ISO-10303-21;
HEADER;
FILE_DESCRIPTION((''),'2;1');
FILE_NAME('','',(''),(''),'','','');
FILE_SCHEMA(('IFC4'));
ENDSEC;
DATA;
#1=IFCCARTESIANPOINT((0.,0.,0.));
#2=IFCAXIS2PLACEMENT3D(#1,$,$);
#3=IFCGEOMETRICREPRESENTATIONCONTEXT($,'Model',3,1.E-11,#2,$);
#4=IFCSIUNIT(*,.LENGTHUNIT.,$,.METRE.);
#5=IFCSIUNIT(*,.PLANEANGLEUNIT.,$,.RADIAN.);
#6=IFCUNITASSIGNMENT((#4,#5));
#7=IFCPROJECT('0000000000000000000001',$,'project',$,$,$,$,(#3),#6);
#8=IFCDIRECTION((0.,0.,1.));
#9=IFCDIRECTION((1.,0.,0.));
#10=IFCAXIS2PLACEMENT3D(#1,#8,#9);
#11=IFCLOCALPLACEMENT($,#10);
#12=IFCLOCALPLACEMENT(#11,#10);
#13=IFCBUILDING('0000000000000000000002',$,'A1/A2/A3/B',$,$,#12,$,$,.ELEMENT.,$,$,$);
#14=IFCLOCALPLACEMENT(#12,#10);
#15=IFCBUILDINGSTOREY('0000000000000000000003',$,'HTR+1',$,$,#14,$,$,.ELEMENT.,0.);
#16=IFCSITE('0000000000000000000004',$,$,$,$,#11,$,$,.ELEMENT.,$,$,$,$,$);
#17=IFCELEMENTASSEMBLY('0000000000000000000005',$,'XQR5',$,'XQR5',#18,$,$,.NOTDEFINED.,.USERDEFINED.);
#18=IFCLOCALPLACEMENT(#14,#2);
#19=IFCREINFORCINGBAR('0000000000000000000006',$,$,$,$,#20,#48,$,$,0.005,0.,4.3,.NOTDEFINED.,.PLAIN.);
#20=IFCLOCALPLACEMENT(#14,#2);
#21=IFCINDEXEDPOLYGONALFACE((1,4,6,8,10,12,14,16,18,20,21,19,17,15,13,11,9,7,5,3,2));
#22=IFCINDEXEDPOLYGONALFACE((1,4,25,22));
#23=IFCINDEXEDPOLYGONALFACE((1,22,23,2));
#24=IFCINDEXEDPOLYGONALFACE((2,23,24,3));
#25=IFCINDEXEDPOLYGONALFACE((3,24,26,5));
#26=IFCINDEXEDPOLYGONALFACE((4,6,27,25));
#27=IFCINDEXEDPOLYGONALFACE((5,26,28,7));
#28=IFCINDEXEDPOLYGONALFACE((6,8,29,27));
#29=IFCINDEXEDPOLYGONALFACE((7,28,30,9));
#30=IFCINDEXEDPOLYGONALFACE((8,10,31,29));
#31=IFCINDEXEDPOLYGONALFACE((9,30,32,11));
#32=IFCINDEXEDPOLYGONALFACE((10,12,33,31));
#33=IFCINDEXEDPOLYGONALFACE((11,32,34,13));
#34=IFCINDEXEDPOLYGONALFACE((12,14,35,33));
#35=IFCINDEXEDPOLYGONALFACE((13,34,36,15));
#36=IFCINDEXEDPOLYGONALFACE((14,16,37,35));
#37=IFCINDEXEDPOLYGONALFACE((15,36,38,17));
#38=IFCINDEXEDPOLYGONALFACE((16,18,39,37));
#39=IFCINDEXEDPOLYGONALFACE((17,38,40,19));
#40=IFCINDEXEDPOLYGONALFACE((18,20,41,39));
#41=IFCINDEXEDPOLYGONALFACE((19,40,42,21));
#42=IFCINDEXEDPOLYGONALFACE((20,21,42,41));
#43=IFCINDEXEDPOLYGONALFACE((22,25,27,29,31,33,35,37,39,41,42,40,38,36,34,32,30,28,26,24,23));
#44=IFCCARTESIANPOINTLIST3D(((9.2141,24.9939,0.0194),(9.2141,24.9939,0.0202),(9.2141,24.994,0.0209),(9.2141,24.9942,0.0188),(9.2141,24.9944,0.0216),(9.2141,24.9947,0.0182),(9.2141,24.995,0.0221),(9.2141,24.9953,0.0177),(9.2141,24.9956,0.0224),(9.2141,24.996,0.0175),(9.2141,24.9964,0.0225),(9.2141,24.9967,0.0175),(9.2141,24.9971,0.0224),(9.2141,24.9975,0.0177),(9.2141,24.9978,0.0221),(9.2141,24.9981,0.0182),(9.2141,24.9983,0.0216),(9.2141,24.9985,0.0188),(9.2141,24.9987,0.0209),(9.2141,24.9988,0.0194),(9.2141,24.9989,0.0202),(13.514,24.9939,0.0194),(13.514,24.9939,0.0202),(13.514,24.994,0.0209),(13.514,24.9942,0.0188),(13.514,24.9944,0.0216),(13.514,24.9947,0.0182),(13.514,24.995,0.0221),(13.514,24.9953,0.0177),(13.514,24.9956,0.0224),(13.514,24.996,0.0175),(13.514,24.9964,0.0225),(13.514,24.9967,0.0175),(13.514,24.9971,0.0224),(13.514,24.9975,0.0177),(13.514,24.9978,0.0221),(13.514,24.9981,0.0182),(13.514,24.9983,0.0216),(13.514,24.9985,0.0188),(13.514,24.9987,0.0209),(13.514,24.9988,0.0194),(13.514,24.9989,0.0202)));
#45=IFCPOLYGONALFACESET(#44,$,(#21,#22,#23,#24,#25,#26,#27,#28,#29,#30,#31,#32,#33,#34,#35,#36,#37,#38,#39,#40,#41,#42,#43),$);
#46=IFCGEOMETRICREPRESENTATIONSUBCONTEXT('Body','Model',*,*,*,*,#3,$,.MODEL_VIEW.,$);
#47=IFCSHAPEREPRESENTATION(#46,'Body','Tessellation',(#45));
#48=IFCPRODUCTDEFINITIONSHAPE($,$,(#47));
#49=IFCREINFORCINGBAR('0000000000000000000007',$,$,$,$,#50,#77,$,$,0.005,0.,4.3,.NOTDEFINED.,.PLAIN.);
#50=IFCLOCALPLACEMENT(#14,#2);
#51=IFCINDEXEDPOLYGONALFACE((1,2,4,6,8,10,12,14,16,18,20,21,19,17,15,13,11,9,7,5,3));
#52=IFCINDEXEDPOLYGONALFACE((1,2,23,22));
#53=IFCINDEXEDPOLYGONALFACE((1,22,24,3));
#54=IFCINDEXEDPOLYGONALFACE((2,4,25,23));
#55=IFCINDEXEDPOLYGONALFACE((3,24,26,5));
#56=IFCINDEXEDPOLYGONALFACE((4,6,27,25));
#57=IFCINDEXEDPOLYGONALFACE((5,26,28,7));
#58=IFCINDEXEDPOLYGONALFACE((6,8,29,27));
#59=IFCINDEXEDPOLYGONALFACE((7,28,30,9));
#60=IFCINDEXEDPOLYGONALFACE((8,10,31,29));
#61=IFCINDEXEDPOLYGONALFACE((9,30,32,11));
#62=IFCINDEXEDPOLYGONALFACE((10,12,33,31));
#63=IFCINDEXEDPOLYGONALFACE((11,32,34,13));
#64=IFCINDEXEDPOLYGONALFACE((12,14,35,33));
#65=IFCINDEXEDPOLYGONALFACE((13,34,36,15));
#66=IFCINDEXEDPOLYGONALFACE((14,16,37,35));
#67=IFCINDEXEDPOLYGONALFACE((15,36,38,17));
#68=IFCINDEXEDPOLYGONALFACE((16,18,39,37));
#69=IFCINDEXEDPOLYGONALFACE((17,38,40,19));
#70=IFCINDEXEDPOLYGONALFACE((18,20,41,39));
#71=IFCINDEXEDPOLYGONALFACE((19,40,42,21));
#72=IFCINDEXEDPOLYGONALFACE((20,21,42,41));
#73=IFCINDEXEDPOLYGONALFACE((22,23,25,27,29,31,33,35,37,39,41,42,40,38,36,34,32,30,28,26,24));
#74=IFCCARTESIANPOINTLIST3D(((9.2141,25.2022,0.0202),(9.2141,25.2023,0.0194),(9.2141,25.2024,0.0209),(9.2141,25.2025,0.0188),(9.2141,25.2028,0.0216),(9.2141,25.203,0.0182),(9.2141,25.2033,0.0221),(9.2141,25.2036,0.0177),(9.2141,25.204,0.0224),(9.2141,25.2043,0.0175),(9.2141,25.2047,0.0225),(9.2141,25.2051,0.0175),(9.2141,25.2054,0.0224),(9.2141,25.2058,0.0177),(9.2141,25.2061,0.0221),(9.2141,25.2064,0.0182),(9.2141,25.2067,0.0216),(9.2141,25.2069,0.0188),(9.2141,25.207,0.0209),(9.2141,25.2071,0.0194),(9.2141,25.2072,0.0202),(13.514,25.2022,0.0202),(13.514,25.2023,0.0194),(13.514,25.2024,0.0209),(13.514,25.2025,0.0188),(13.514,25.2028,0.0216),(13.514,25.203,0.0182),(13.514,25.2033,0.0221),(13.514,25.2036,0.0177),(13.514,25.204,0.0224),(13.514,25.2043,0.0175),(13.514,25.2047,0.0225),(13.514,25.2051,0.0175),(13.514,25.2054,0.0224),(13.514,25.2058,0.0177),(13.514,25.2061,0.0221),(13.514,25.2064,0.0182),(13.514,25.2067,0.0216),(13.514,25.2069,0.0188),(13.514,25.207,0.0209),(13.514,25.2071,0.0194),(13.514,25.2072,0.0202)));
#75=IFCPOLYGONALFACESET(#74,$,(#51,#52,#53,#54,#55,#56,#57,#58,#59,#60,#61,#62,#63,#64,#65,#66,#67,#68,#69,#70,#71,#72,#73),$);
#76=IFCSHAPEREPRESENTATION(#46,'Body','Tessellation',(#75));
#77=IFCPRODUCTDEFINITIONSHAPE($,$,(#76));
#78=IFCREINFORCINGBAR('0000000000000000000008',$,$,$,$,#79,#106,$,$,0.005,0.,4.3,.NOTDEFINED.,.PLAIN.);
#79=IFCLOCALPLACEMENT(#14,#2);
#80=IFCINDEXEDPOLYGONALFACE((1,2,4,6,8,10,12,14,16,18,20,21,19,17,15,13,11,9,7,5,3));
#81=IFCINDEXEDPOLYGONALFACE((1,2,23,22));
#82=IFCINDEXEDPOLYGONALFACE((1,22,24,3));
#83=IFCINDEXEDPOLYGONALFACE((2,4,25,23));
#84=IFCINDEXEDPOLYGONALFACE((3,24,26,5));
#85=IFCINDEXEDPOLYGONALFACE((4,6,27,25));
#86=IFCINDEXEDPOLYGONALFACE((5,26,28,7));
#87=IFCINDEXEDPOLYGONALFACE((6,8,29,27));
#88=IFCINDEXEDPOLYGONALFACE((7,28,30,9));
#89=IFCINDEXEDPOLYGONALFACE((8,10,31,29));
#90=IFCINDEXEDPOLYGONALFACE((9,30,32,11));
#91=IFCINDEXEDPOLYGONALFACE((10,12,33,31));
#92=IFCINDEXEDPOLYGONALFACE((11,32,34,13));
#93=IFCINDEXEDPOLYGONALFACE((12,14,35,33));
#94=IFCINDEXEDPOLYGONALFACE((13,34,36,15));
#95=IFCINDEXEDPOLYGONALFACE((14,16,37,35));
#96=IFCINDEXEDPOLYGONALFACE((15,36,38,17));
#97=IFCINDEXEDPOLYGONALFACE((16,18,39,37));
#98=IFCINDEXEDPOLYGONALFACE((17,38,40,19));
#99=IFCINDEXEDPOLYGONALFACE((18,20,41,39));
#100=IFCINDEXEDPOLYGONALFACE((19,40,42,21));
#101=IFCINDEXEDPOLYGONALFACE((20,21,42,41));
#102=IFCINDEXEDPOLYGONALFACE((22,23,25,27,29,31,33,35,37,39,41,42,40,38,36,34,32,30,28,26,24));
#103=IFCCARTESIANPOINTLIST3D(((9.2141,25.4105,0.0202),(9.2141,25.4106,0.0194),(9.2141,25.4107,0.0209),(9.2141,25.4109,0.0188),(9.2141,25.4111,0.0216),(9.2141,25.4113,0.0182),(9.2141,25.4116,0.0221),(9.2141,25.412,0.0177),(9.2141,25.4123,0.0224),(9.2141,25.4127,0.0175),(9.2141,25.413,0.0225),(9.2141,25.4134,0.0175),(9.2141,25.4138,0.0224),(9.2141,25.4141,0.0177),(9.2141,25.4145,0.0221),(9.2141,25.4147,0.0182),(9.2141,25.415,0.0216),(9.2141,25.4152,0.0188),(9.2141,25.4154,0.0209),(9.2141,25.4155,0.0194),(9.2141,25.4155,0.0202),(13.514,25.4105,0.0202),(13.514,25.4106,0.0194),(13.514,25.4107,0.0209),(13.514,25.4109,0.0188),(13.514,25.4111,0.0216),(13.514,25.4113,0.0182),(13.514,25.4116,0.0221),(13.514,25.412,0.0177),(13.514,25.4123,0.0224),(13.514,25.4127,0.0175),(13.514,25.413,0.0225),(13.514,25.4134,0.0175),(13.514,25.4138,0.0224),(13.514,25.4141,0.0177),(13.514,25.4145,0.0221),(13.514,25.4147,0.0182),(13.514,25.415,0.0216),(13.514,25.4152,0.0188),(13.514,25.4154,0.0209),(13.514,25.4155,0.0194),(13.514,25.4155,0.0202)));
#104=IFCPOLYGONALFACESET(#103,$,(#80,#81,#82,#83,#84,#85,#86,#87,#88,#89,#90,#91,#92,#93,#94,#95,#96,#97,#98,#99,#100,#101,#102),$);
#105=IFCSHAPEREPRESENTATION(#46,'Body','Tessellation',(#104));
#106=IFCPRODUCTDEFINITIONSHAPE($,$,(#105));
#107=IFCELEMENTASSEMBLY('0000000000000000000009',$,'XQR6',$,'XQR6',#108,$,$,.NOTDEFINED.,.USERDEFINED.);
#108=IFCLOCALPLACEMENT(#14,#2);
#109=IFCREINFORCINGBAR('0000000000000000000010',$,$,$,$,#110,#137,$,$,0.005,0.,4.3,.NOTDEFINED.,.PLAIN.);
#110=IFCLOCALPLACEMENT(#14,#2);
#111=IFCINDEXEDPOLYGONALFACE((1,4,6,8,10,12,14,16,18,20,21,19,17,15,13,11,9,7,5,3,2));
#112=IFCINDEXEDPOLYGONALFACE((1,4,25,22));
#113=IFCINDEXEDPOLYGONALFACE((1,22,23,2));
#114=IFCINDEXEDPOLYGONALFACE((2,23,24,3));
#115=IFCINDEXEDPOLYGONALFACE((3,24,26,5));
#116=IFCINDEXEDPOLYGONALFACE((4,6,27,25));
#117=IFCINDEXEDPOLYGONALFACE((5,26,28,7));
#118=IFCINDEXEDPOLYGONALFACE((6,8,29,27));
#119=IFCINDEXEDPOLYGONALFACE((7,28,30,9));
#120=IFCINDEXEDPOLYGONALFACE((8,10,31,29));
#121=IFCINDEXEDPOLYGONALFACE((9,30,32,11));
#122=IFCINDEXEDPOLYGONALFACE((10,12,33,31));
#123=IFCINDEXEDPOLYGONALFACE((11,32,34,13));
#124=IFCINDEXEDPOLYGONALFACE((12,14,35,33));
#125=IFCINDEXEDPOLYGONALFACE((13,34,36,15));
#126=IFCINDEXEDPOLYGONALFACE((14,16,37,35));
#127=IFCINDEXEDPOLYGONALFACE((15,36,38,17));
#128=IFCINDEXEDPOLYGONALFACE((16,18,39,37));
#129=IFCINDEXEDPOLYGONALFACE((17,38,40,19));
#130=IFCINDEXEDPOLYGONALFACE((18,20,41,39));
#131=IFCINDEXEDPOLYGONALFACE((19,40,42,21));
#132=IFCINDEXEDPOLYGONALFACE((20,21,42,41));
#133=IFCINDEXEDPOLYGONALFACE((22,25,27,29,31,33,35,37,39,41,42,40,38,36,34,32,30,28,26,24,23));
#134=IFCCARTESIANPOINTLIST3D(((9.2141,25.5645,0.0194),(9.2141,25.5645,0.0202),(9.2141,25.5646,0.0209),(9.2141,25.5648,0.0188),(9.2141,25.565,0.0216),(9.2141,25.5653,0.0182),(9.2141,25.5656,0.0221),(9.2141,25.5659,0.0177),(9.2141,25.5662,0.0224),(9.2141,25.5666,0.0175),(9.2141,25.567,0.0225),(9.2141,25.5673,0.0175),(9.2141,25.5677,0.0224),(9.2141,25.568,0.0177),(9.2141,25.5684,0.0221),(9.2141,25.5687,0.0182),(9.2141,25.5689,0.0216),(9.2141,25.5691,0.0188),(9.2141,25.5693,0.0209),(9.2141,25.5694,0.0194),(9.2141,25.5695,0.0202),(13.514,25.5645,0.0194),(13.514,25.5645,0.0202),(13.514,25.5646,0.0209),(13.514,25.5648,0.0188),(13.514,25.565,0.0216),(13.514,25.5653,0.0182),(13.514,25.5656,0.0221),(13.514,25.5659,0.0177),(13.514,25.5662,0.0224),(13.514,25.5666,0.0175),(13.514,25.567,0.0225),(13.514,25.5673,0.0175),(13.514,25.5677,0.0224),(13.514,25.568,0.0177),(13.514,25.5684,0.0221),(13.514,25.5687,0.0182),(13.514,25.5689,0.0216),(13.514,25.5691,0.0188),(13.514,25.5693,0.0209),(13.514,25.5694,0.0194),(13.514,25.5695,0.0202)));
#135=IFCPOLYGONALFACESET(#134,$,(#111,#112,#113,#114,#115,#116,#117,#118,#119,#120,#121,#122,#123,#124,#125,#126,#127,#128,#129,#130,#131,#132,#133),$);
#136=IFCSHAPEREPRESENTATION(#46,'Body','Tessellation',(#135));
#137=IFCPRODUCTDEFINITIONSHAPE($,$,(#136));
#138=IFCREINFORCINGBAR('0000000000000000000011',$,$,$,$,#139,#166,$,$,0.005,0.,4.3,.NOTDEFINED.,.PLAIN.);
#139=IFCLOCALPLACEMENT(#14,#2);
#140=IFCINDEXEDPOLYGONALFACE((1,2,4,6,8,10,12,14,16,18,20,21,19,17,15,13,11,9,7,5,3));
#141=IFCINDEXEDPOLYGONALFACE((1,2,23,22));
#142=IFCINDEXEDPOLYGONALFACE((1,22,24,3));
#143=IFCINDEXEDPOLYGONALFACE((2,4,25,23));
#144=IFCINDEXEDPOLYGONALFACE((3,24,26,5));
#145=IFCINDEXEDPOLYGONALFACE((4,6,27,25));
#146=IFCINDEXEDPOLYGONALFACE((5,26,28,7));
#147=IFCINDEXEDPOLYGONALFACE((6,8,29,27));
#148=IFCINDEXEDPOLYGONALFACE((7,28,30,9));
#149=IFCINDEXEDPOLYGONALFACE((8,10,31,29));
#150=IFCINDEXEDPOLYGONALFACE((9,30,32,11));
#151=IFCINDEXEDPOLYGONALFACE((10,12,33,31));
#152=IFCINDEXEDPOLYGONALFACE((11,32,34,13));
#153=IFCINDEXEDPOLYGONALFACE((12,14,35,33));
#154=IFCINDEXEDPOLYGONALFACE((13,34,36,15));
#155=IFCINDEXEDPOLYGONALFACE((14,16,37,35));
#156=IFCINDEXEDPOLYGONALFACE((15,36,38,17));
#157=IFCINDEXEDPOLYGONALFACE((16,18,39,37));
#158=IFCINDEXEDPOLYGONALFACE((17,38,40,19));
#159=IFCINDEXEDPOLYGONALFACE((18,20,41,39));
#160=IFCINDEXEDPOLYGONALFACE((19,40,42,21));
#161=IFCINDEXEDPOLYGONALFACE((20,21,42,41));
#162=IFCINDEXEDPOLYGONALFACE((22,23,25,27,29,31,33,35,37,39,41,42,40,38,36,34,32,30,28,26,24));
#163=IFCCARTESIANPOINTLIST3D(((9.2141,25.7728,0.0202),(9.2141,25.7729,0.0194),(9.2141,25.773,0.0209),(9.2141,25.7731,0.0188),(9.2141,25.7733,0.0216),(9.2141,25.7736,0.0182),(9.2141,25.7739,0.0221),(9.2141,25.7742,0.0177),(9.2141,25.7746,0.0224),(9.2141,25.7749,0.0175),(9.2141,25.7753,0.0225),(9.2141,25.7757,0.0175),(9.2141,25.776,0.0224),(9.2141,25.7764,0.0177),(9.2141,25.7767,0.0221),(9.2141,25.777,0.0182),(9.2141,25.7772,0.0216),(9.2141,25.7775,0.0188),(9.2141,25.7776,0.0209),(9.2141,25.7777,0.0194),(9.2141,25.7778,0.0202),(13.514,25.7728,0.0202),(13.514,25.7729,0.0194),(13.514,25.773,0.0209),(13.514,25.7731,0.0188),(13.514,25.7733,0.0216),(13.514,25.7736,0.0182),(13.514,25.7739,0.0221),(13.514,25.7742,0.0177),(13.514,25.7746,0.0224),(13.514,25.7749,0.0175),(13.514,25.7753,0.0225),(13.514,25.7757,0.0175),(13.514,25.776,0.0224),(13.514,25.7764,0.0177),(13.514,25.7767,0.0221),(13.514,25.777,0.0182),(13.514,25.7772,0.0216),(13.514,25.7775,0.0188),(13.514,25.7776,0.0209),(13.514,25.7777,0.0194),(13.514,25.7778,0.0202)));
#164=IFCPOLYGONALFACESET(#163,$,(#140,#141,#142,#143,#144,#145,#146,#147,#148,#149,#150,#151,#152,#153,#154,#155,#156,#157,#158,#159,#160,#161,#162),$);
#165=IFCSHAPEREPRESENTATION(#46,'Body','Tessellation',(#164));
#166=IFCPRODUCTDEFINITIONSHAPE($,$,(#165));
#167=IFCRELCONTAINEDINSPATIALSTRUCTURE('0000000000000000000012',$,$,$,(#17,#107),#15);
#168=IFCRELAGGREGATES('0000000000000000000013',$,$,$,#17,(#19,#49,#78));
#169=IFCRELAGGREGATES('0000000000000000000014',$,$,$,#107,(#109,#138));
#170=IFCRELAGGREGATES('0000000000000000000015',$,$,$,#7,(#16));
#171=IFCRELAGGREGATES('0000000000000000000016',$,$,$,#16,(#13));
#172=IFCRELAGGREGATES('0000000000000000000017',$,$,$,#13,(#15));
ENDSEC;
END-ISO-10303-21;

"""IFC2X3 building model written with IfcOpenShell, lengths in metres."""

from ifc_helpers import new_model, entity, si_unit, origin, origin_with_axes, place, context, subcontext, project, spatial, shape, element, aggregate, save


model = new_model("IFC2X3")

# Units and contexts
model_context = context("Model", 3, precision=1e-11, world=origin())
body_context = subcontext(model_context, "Body", "Model", "MODEL_VIEW")
ifc_project = project(units=[si_unit("LENGTHUNIT", "METRE"), si_unit("PLANEANGLEUNIT", "RADIAN")], contexts=[model_context])

# Site, building, storey
site_placement = place(None, origin_with_axes())
site = spatial("IfcSite", under=ifc_project, at=site_placement, CompositionType="ELEMENT")
building_placement = place(site_placement, origin_with_axes())
building = spatial("IfcBuilding", under=site, at=building_placement, Name="A1/A2/A3/B", CompositionType="ELEMENT")
storey_placement = place(building_placement, origin_with_axes())
storey = spatial("IfcBuildingStorey", under=building, at=storey_placement, Name="HTR+1", CompositionType="ELEMENT", Elevation=0.0)

# Element assemblies, reinforcing bars
assembly_1_placement = place(storey_placement, origin_with_axes())
assembly_1 = element("IfcElementAssembly", 1, at=assembly_1_placement, inside=storey, Name="XQR5", ObjectType="XQR5", AssemblyPlace="NOTDEFINED", PredefinedType="USERDEFINED")
reinforcing_bar_1_placement = place(assembly_1_placement, origin_with_axes())
reinforcing_bar_1 = element("IfcReinforcingBar", 2, at=reinforcing_bar_1_placement, BarLength=4.3, BarRole="NOTDEFINED", BarSurface="PLAIN", CrossSectionArea=0.0, NominalDiameter=0.005, shapes=[
    shape(body_context, "Body", "AdvancedSweptSolid", [entity("IfcSweptDiskSolid", entity("IfcPolyline", [entity("IfcCartesianPoint", [9.2141, 24.9964, 0.02]), entity("IfcCartesianPoint", [13.514, 24.9964, 0.02])]), 0.0025, None, 0.0, 4.3)]),
    shape(body_context, "Body", "AdvancedSweptSolid", [entity("IfcSweptDiskSolid", entity("IfcPolyline", [entity("IfcCartesianPoint", [9.2141, 24.9964, 0.02]), entity("IfcCartesianPoint", [13.514, 24.9964, 0.02])]), 0.0025, None, 0.0, 4.3)]),
])
reinforcing_bar_2_placement = place(assembly_1_placement, origin_with_axes())
reinforcing_bar_2 = element("IfcReinforcingBar", 3, at=reinforcing_bar_2_placement, BarLength=4.3, BarRole="NOTDEFINED", BarSurface="PLAIN", CrossSectionArea=0.0, NominalDiameter=0.005, shapes=[
    shape(body_context, "Body", "AdvancedSweptSolid", [entity("IfcSweptDiskSolid", entity("IfcPolyline", [entity("IfcCartesianPoint", [9.2141, 25.2047, 0.02]), entity("IfcCartesianPoint", [13.514, 25.2047, 0.02])]), 0.0025, None, 0.0, 4.3)]),
    shape(body_context, "Body", "AdvancedSweptSolid", [entity("IfcSweptDiskSolid", entity("IfcPolyline", [entity("IfcCartesianPoint", [9.2141, 25.2047, 0.02]), entity("IfcCartesianPoint", [13.514, 25.2047, 0.02])]), 0.0025, None, 0.0, 4.3)]),
])
reinforcing_bar_3_placement = place(assembly_1_placement, origin_with_axes())
reinforcing_bar_3 = element("IfcReinforcingBar", 4, at=reinforcing_bar_3_placement, BarLength=4.3, BarRole="NOTDEFINED", BarSurface="PLAIN", CrossSectionArea=0.0, NominalDiameter=0.005, shapes=[
    shape(body_context, "Body", "AdvancedSweptSolid", [entity("IfcSweptDiskSolid", entity("IfcPolyline", [entity("IfcCartesianPoint", [9.2141, 25.413, 0.02]), entity("IfcCartesianPoint", [13.514, 25.413, 0.02])]), 0.0025, None, 0.0, 4.3)]),
    shape(body_context, "Body", "AdvancedSweptSolid", [entity("IfcSweptDiskSolid", entity("IfcPolyline", [entity("IfcCartesianPoint", [9.2141, 25.413, 0.02]), entity("IfcCartesianPoint", [13.514, 25.413, 0.02])]), 0.0025, None, 0.0, 4.3)]),
])
aggregate(assembly_1, [reinforcing_bar_1, reinforcing_bar_2, reinforcing_bar_3])
assembly_2_placement = place(storey_placement, origin_with_axes())
assembly_2 = element("IfcElementAssembly", 5, at=assembly_2_placement, inside=storey, Name="XQR6", ObjectType="XQR6", AssemblyPlace="NOTDEFINED", PredefinedType="USERDEFINED")
reinforcing_bar_4_placement = place(assembly_2_placement, origin_with_axes())
reinforcing_bar_4 = element("IfcReinforcingBar", 6, at=reinforcing_bar_4_placement, BarLength=4.3, BarRole="NOTDEFINED", BarSurface="PLAIN", CrossSectionArea=0.0, NominalDiameter=0.005, shapes=[
    shape(body_context, "Body", "AdvancedSweptSolid", [entity("IfcSweptDiskSolid", entity("IfcPolyline", [entity("IfcCartesianPoint", [9.2141, 25.567, 0.02]), entity("IfcCartesianPoint", [13.514, 25.567, 0.02])]), 0.0025, None, 0.0, 4.3)]),
    shape(body_context, "Body", "AdvancedSweptSolid", [entity("IfcSweptDiskSolid", entity("IfcPolyline", [entity("IfcCartesianPoint", [9.2141, 25.567, 0.02]), entity("IfcCartesianPoint", [13.514, 25.567, 0.02])]), 0.0025, None, 0.0, 4.3)]),
])
reinforcing_bar_5_placement = place(assembly_2_placement, origin_with_axes())
reinforcing_bar_5 = element("IfcReinforcingBar", 7, at=reinforcing_bar_5_placement, BarLength=4.3, BarRole="NOTDEFINED", BarSurface="PLAIN", CrossSectionArea=0.0, NominalDiameter=0.005, shapes=[
    shape(body_context, "Body", "AdvancedSweptSolid", [entity("IfcSweptDiskSolid", entity("IfcPolyline", [entity("IfcCartesianPoint", [9.2141, 25.7753, 0.02]), entity("IfcCartesianPoint", [13.514, 25.7753, 0.02])]), 0.0025, None, 0.0, 4.3)]),
    shape(body_context, "Body", "AdvancedSweptSolid", [entity("IfcSweptDiskSolid", entity("IfcPolyline", [entity("IfcCartesianPoint", [9.2141, 25.7753, 0.02]), entity("IfcCartesianPoint", [13.514, 25.7753, 0.02])]), 0.0025, None, 0.0, 4.3)]),
])
aggregate(assembly_2, [reinforcing_bar_4, reinforcing_bar_5])

save(model, "model.ifc")
